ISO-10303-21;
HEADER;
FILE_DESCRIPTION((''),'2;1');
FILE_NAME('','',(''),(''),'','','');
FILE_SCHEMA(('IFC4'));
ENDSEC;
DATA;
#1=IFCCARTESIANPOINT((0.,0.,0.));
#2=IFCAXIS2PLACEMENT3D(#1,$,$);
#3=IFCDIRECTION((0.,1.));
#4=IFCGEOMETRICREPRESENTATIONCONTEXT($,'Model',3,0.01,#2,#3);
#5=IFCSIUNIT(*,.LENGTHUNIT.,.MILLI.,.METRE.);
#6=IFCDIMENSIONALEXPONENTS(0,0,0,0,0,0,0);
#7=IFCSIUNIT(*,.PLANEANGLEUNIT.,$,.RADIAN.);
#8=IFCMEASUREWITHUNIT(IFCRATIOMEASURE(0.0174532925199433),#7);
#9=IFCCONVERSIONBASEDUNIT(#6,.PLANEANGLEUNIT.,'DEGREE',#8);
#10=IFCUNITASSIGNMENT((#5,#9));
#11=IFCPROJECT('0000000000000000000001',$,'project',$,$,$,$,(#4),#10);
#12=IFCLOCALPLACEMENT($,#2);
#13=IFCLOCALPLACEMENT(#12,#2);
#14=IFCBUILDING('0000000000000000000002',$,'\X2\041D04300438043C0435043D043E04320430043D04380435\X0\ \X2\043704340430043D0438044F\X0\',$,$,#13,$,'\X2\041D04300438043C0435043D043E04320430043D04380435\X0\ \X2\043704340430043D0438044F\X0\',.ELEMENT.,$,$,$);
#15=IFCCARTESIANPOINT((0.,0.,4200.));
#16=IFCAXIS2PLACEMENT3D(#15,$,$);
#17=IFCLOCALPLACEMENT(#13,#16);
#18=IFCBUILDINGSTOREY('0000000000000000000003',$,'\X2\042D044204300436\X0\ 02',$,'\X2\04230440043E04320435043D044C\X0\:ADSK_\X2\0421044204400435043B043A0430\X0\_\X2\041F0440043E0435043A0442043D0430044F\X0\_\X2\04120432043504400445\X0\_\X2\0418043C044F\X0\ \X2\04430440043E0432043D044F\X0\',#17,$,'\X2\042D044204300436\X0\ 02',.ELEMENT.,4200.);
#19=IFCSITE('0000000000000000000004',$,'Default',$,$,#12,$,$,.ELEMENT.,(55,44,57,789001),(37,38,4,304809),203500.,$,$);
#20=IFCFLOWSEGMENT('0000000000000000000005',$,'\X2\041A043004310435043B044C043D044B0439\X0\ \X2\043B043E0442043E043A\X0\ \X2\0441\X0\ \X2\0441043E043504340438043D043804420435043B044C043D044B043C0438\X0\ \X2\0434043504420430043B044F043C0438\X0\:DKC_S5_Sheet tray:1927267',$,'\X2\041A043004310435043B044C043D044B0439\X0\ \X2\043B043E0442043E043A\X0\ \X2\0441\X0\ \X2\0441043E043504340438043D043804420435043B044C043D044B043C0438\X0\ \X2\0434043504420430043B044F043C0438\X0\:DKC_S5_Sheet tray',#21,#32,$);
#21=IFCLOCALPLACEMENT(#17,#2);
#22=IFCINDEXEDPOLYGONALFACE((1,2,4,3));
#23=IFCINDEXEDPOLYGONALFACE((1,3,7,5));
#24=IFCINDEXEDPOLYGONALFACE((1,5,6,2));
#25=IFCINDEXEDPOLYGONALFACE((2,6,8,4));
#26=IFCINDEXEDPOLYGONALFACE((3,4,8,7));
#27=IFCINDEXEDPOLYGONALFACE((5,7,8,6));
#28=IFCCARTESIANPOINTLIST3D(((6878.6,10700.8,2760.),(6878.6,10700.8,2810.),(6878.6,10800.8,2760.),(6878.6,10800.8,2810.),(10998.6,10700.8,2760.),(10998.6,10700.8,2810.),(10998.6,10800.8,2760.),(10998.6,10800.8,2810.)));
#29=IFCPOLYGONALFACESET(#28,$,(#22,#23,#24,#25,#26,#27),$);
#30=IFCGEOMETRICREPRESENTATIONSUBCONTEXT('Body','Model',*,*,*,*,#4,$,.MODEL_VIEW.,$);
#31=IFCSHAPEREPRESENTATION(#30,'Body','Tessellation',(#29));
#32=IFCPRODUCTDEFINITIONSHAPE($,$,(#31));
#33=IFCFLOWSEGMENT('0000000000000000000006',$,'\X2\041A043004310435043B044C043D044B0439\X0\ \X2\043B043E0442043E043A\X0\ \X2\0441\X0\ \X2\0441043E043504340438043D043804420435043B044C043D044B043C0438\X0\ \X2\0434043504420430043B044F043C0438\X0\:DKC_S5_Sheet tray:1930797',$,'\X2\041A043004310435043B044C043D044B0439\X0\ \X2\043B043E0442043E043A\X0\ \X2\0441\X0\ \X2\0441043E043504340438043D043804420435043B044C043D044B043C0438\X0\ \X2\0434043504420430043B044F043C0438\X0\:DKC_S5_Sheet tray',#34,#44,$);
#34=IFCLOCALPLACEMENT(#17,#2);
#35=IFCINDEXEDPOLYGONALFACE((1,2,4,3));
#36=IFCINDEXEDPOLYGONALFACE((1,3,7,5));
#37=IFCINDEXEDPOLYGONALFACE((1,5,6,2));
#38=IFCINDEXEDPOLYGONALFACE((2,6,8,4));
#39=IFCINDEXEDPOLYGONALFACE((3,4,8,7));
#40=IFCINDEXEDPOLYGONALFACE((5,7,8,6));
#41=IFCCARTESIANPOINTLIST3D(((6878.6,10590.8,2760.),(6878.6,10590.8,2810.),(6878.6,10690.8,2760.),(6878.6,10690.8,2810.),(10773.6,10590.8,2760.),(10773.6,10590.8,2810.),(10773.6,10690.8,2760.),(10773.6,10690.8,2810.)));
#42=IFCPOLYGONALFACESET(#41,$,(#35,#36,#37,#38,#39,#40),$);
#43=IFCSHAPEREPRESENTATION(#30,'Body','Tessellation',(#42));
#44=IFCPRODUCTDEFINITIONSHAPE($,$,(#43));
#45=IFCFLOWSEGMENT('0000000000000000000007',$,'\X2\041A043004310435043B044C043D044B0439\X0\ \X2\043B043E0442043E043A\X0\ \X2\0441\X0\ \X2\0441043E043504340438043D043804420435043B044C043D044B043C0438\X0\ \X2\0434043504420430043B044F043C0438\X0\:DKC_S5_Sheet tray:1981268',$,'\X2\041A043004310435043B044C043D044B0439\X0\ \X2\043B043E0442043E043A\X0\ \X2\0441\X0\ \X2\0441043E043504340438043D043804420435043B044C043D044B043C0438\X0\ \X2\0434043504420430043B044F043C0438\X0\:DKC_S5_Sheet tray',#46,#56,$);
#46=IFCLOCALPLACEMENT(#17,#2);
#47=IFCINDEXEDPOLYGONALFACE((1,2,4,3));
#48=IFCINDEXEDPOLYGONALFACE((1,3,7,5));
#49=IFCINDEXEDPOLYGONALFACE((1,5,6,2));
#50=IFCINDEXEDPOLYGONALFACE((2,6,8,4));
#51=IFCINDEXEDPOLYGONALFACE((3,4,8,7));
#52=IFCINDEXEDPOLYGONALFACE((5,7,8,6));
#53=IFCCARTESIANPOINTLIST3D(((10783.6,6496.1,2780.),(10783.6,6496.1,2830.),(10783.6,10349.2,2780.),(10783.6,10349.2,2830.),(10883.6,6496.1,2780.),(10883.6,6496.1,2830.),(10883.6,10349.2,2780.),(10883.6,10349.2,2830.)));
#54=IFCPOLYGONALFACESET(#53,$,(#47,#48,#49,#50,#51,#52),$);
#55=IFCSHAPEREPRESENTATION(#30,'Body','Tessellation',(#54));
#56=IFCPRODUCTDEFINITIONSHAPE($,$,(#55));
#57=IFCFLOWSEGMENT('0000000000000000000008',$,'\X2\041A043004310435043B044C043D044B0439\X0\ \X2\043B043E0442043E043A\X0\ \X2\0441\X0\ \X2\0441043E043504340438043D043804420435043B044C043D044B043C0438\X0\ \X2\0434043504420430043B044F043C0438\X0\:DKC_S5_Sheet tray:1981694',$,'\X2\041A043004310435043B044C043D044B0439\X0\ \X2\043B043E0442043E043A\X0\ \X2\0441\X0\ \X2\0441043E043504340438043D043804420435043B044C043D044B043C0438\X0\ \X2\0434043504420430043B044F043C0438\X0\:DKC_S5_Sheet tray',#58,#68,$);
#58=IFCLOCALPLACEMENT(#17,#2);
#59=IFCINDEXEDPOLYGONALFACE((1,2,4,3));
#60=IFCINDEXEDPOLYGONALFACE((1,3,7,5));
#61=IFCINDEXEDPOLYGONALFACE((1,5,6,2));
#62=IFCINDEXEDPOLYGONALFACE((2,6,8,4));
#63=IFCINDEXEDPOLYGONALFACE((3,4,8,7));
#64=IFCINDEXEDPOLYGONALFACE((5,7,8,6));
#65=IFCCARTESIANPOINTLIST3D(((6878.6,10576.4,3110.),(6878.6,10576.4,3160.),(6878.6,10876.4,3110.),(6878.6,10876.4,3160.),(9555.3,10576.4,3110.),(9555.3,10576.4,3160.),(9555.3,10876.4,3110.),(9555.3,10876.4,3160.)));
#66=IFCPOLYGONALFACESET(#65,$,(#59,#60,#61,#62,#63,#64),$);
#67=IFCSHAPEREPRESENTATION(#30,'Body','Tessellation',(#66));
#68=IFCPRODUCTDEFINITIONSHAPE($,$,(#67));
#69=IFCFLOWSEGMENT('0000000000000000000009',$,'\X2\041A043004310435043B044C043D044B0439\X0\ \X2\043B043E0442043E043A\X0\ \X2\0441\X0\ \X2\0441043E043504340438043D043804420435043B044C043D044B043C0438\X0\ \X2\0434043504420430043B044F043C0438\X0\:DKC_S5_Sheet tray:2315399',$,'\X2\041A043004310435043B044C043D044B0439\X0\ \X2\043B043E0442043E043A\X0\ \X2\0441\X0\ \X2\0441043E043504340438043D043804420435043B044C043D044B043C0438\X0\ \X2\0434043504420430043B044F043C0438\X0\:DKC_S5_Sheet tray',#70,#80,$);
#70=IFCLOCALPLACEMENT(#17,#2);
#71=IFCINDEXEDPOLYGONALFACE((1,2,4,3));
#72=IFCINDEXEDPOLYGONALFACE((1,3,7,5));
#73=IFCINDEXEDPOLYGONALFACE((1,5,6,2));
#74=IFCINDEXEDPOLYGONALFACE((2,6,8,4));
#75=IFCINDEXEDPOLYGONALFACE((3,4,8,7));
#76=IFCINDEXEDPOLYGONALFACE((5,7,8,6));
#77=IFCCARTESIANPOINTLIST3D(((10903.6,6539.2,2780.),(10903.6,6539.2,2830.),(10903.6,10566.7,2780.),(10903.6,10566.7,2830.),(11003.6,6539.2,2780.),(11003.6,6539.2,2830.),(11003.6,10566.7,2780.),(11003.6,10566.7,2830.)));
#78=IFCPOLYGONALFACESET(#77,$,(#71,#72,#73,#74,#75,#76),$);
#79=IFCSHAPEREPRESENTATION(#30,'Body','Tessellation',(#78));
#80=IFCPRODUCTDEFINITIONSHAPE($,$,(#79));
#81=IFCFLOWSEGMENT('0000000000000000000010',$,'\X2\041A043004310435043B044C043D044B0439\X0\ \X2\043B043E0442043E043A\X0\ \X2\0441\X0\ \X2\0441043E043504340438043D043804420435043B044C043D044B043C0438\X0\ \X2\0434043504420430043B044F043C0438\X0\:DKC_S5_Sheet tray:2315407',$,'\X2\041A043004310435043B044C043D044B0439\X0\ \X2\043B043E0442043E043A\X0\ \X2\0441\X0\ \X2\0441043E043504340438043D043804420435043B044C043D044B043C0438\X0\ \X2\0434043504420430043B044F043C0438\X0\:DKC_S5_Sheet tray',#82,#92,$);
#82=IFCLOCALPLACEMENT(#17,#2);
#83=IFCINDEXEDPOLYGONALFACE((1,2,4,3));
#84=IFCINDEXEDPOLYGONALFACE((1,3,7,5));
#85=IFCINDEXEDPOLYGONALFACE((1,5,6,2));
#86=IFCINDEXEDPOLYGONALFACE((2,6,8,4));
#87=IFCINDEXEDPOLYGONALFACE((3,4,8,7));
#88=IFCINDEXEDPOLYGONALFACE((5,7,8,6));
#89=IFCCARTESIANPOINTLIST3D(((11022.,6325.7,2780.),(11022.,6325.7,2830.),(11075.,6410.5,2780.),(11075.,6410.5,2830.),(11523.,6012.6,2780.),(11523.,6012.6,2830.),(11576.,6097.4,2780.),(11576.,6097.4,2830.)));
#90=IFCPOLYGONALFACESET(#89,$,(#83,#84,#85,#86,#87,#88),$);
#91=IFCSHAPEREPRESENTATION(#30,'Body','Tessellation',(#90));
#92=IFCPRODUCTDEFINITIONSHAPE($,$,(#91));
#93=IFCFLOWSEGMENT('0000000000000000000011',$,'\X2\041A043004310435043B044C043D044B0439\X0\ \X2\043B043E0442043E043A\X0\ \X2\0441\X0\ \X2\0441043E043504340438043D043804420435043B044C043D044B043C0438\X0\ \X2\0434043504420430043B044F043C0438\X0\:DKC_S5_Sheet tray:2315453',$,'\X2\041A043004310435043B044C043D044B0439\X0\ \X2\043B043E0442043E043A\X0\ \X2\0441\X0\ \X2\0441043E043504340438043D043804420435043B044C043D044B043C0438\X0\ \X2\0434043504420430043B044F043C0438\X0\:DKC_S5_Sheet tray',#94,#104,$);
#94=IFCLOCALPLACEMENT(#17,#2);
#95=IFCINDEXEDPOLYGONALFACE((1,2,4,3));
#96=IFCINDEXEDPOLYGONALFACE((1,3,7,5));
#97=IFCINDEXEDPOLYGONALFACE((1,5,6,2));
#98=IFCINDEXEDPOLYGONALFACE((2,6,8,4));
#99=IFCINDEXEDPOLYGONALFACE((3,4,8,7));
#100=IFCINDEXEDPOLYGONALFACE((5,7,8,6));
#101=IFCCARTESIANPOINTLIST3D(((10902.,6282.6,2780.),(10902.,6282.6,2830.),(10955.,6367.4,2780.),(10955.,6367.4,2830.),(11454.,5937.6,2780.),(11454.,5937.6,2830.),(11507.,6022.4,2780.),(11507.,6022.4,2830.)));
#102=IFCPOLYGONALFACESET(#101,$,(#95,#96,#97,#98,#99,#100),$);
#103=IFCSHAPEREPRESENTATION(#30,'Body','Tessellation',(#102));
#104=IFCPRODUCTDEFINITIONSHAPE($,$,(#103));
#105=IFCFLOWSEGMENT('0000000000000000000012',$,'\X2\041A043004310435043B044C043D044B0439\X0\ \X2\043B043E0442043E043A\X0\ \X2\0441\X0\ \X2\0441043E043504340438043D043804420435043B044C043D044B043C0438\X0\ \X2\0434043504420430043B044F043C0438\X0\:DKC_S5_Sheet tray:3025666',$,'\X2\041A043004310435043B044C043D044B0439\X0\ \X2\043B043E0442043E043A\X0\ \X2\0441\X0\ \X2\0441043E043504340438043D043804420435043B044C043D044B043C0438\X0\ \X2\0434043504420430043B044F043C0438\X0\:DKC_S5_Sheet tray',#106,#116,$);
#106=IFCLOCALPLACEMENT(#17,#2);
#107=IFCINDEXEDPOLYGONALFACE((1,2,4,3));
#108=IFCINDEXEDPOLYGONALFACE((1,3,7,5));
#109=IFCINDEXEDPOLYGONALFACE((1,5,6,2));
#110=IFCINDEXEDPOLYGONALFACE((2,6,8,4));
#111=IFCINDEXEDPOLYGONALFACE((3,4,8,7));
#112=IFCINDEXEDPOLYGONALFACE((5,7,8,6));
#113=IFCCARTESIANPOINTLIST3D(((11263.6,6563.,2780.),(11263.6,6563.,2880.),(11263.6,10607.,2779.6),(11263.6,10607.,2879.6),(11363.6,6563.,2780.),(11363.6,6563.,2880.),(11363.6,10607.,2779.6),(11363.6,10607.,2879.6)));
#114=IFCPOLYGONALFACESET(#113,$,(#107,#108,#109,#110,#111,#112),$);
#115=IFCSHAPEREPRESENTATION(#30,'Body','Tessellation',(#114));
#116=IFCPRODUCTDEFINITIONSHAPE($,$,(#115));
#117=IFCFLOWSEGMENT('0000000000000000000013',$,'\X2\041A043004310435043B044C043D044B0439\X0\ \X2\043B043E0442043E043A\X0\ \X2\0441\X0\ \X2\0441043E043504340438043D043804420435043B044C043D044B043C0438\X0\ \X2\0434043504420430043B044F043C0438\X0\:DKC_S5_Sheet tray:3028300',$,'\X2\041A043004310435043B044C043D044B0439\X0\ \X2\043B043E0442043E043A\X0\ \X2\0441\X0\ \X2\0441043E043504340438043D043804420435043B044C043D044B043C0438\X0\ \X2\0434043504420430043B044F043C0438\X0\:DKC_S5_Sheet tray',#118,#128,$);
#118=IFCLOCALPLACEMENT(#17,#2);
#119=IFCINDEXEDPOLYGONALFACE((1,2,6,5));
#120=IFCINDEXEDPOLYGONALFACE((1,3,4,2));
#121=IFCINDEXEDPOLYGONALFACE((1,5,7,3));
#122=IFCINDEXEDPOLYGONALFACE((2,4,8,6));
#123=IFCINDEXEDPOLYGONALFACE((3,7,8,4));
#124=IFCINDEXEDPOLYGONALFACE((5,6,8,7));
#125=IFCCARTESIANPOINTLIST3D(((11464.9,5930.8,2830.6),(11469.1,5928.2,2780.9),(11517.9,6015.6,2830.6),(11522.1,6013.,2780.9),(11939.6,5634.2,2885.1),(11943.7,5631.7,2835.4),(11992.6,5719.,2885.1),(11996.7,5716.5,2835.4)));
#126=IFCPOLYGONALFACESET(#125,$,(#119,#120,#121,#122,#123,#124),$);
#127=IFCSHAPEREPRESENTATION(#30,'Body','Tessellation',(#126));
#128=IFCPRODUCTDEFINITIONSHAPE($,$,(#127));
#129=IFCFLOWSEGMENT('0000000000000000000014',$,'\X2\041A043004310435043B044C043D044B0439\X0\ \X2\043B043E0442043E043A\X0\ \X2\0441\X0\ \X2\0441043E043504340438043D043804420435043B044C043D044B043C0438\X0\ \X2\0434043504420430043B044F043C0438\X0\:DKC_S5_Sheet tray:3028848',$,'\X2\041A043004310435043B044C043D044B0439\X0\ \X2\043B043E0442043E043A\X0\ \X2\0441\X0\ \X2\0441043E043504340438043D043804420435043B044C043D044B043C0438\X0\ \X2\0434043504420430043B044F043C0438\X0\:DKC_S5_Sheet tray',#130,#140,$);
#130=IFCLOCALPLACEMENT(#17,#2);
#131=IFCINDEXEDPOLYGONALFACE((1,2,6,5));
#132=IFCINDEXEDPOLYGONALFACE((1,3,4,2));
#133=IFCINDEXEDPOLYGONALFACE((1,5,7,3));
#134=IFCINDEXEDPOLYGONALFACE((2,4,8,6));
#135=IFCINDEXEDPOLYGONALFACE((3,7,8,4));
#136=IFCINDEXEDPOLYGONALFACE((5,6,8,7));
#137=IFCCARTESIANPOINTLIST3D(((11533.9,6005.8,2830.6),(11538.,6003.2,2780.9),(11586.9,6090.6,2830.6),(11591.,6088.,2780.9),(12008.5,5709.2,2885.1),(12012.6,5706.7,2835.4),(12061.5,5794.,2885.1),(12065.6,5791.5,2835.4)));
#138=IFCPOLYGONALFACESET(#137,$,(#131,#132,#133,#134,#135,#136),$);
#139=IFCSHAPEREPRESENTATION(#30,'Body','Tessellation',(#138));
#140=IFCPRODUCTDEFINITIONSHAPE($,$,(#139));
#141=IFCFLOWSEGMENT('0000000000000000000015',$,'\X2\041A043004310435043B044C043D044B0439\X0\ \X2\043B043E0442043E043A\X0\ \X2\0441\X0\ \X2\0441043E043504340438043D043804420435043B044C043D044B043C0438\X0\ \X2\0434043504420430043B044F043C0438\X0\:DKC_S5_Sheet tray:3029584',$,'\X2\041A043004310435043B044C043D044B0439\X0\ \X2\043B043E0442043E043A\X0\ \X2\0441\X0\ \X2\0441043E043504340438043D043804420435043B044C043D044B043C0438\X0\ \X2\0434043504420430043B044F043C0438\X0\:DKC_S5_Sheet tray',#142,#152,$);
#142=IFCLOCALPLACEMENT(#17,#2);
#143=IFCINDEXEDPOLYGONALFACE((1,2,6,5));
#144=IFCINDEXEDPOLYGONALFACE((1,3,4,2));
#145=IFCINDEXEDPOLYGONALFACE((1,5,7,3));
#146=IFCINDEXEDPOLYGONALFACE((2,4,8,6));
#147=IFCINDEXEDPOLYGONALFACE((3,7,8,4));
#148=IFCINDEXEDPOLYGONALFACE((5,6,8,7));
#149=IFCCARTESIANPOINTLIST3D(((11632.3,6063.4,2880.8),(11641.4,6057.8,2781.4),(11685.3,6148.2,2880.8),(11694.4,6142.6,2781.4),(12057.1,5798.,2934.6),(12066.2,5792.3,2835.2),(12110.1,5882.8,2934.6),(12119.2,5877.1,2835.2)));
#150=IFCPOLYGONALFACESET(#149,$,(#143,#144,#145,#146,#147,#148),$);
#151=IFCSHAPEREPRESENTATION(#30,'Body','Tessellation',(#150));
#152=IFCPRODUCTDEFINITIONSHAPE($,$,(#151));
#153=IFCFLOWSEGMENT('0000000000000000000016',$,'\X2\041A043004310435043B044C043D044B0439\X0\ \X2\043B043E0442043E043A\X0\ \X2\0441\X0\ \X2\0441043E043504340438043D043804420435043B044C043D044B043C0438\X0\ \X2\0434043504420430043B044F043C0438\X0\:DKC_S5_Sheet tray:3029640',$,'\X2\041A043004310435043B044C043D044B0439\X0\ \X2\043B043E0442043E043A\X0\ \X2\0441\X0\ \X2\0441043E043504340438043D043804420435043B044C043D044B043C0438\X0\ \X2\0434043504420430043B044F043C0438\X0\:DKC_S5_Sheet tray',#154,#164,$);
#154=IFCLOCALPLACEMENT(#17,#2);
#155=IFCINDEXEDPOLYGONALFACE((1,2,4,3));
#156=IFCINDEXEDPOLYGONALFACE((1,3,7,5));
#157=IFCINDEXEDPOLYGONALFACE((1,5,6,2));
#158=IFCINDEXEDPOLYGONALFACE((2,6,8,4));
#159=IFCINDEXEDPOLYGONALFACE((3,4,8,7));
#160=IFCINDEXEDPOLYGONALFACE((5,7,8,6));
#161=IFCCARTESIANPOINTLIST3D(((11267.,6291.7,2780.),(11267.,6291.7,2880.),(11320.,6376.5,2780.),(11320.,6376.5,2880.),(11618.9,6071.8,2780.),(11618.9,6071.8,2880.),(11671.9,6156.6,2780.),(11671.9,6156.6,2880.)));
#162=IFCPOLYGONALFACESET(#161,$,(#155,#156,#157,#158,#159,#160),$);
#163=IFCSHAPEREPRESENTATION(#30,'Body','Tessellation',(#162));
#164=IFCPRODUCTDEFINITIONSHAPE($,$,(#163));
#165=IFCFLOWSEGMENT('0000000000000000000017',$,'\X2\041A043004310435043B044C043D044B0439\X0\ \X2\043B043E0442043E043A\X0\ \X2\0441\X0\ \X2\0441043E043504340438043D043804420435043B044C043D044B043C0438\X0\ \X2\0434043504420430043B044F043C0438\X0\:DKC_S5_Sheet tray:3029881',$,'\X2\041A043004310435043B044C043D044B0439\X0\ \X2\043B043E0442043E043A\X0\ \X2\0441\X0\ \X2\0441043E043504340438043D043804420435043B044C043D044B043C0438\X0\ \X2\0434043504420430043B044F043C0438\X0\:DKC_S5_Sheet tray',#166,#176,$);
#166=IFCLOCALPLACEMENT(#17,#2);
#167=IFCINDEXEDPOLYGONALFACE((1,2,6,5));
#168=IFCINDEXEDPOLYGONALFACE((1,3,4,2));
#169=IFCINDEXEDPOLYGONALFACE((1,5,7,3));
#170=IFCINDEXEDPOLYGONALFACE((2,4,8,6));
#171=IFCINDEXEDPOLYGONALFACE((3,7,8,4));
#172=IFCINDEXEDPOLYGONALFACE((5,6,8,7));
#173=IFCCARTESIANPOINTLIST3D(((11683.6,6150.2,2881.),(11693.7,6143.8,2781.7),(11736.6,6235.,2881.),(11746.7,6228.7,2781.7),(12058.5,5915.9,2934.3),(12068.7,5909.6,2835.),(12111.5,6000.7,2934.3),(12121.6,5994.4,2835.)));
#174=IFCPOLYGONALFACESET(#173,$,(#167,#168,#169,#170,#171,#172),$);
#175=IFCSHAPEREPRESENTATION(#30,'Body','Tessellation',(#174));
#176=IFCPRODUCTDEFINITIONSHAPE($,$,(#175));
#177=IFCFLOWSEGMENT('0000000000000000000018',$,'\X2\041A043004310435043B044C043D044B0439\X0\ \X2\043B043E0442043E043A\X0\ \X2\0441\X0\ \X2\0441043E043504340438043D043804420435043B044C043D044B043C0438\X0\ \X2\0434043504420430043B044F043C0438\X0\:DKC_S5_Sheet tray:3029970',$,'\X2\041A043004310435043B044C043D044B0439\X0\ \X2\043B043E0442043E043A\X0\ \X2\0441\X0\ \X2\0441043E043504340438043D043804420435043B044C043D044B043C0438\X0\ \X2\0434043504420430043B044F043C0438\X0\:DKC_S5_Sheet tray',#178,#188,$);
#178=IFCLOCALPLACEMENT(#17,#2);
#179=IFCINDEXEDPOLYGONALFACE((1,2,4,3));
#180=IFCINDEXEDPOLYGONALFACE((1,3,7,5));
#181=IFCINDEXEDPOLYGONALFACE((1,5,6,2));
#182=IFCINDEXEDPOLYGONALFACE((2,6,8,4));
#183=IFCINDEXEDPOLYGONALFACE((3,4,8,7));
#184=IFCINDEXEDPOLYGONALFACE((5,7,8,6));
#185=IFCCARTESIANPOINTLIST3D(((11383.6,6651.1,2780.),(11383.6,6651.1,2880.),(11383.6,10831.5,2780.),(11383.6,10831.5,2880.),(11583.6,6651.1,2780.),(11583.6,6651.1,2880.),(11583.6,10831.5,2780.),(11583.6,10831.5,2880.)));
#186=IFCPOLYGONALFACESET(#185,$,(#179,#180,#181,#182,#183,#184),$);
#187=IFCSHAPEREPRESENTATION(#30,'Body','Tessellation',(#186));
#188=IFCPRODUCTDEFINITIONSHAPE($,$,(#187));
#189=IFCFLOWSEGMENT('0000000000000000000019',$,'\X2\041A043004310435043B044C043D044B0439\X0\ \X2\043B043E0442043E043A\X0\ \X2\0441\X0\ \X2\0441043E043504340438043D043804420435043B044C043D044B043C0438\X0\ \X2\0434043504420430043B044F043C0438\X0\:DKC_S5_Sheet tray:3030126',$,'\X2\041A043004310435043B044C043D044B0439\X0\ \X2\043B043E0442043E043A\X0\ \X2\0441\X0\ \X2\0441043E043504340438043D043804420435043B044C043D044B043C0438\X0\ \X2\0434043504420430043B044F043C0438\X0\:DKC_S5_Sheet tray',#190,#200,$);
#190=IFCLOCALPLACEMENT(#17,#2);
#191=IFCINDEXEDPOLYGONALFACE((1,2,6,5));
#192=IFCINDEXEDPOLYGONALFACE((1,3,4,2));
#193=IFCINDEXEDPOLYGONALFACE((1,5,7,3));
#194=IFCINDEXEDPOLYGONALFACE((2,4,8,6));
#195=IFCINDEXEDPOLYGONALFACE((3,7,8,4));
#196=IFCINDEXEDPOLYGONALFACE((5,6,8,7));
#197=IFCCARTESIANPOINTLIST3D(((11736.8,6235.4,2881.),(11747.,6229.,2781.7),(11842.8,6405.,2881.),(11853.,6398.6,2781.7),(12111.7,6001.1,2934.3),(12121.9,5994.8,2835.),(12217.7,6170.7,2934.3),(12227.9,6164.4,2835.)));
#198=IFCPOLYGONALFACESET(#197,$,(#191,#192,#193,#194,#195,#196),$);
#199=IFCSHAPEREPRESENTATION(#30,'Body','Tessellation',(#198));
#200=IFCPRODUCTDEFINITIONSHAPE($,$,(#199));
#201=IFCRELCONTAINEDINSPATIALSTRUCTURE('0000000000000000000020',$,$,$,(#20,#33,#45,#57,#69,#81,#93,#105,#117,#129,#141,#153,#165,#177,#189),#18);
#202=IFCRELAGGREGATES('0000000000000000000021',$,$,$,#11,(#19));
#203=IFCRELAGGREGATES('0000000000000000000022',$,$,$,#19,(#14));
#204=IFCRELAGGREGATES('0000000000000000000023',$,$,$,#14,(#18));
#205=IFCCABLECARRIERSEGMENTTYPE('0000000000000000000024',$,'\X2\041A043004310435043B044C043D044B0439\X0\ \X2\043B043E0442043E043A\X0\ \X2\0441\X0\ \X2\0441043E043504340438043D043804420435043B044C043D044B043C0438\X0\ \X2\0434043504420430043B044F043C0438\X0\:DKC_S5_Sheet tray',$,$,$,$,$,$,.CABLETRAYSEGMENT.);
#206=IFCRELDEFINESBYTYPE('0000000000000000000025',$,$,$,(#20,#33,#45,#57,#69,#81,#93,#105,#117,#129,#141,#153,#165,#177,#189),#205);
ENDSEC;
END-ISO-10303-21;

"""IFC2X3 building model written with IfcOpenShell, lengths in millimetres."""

from ifc_helpers import new_model, entity, si_unit, converted_unit, direction, frame, frame_2d, origin, origin_2d_with_axis, place, context, subcontext, project, spatial, rectangle, extrude, type_object, element, save


model = new_model("IFC2X3")

# Units and contexts
model_context = context("Model", 3, precision=0.01, world=origin(), true_north=direction((0.0, 1.0)))
body_context = subcontext(model_context, "Body", "Model", "MODEL_VIEW")
ifc_project = project(units=[si_unit("LENGTHUNIT", "METRE", prefix="MILLI"), converted_unit("PLANEANGLEUNIT", "DEGREE", entity("IfcRatioMeasure", 0.0174532925199433), si_unit("PLANEANGLEUNIT", "RADIAN"), dimensions=[0, 0, 0, 0, 0, 0, 0])], contexts=[model_context])

# Site, building, storey
site_placement = place(None, origin())
site = spatial("IfcSite", under=ifc_project, at=site_placement, Name="Default", CompositionType="ELEMENT", RefLatitude=(55, 44, 57, 789001), RefLongitude=(37, 38, 4, 304809), RefElevation=203500.0)
building_placement = place(site_placement, origin())
building = spatial("IfcBuilding", under=site, at=building_placement, Name="Наименование здания", LongName="Наименование здания", CompositionType="ELEMENT")
storey_placement = place(building_placement, frame((0.0, 0.0, 4200.0)))
storey = spatial("IfcBuildingStorey", under=building, at=storey_placement, Name="Этаж 02", ObjectType="Уровень:ADSK_Стрелка_Проектная_Вверх_Имя уровня", LongName="Этаж 02", CompositionType="ELEMENT", Elevation=4200.0)

# Flow segments
cable_carrier_segment_type = type_object("IfcCableCarrierSegmentType", Name="Кабельный лоток с соединительными деталями:DKC_S5_Sheet tray", PredefinedType="CABLETRAYSEGMENT")
flow_segment_1_placement = place(storey_placement, frame((6878.6, 10700.8, 2760.0)))
element("IfcFlowSegment", 1, at=flow_segment_1_placement, inside=storey, type_object=cable_carrier_segment_type, Name="Кабельный лоток с соединительными деталями:DKC_S5_Sheet tray:1927267", ObjectType="Кабельный лоток с соединительными деталями:DKC_S5_Sheet tray", context=body_context, shape_type="SweptSolid", body=[
    extrude(rectangle(XDim=4120.0, YDim=100.0, at=origin_2d_with_axis()), frame((2060.0, 50.0, 0.0), z_axis=(0.0, 0.0, 1.0), x_axis=(-1.0, 0.0, 0.0)), (0.0, 0.0, 1.0), 50.0),
])
flow_segment_2_placement = place(storey_placement, frame((6878.6, 10590.8, 2760.0)))
element("IfcFlowSegment", 2, at=flow_segment_2_placement, inside=storey, type_object=cable_carrier_segment_type, Name="Кабельный лоток с соединительными деталями:DKC_S5_Sheet tray:1930797", ObjectType="Кабельный лоток с соединительными деталями:DKC_S5_Sheet tray", context=body_context, shape_type="SweptSolid", body=[
    extrude(rectangle(XDim=3895.0, YDim=100.0, at=origin_2d_with_axis()), frame((1947.5, 50.0, 0.0), z_axis=(0.0, 0.0, 1.0), x_axis=(-1.0, 0.0, 0.0)), (0.0, 0.0, 1.0), 50.0),
])
flow_segment_3_placement = place(storey_placement, frame((10783.6, 6496.1, 2780.0)))
element("IfcFlowSegment", 3, at=flow_segment_3_placement, inside=storey, type_object=cable_carrier_segment_type, Name="Кабельный лоток с соединительными деталями:DKC_S5_Sheet tray:1981268", ObjectType="Кабельный лоток с соединительными деталями:DKC_S5_Sheet tray", context=body_context, shape_type="SweptSolid", body=[
    extrude(rectangle(XDim=3853.0, YDim=100.0, at=origin_2d_with_axis()), frame((50.0, 1926.5, 0.0), z_axis=(0.0, 0.0, 1.0), x_axis=(0.0, -1.0, 0.0)), (0.0, 0.0, 1.0), 50.0),
])
flow_segment_4_placement = place(storey_placement, frame((6878.6, 10576.4, 3110.0)))
element("IfcFlowSegment", 4, at=flow_segment_4_placement, inside=storey, type_object=cable_carrier_segment_type, Name="Кабельный лоток с соединительными деталями:DKC_S5_Sheet tray:1981694", ObjectType="Кабельный лоток с соединительными деталями:DKC_S5_Sheet tray", context=body_context, shape_type="SweptSolid", body=[
    extrude(rectangle(XDim=2676.7, YDim=300.0, at=origin_2d_with_axis()), frame((1338.3, 150.0, 0.0), z_axis=(0.0, 0.0, 1.0), x_axis=(-1.0, 0.0, 0.0)), (0.0, 0.0, 1.0), 50.0),
])
flow_segment_5_placement = place(storey_placement, frame((10903.6, 6539.2, 2780.0)))
element("IfcFlowSegment", 5, at=flow_segment_5_placement, inside=storey, type_object=cable_carrier_segment_type, Name="Кабельный лоток с соединительными деталями:DKC_S5_Sheet tray:2315399", ObjectType="Кабельный лоток с соединительными деталями:DKC_S5_Sheet tray", context=body_context, shape_type="SweptSolid", body=[
    extrude(rectangle(XDim=4027.5, YDim=100.0, at=origin_2d_with_axis()), frame((50.0, 2013.7, 0.0), z_axis=(0.0, 0.0, 1.0), x_axis=(0.0, -1.0, 0.0)), (0.0, 0.0, 1.0), 50.0),
])
flow_segment_6_placement = place(storey_placement, frame((11022.0, 6012.6, 2780.0)))
element("IfcFlowSegment", 6, at=flow_segment_6_placement, inside=storey, type_object=cable_carrier_segment_type, Name="Кабельный лоток с соединительными деталями:DKC_S5_Sheet tray:2315407", ObjectType="Кабельный лоток с соединительными деталями:DKC_S5_Sheet tray", context=body_context, shape_type="SweptSolid", body=[
    extrude(rectangle(XDim=590.8, YDim=100.0, at=origin_2d_with_axis()), frame((277.0, 198.9, 0.0), z_axis=(0.0, 0.0, 1.0), x_axis=(-0.848048, 0.529919, 0.0)), (0.0, 0.0, 1.0), 50.0),
])
flow_segment_7_placement = place(storey_placement, frame((10902.0, 5937.6, 2780.0)))
element("IfcFlowSegment", 7, at=flow_segment_7_placement, inside=storey, type_object=cable_carrier_segment_type, Name="Кабельный лоток с соединительными деталями:DKC_S5_Sheet tray:2315453", ObjectType="Кабельный лоток с соединительными деталями:DKC_S5_Sheet tray", context=body_context, shape_type="SweptSolid", body=[
    extrude(rectangle(XDim=651.0, YDim=100.0, at=origin_2d_with_axis()), frame((302.5, 214.9, 0.0), z_axis=(0.0, 0.0, 1.0), x_axis=(-0.848048, 0.529919, 0.0)), (0.0, 0.0, 1.0), 50.0),
])
flow_segment_8_placement = place(storey_placement, frame((11263.6, 6563.0, 2779.6)))
element("IfcFlowSegment", 8, at=flow_segment_8_placement, inside=storey, type_object=cable_carrier_segment_type, Name="Кабельный лоток с соединительными деталями:DKC_S5_Sheet tray:3025666", ObjectType="Кабельный лоток с соединительными деталями:DKC_S5_Sheet tray", context=body_context, shape_type="SweptSolid", body=[
    extrude(rectangle(XDim=4044.1, YDim=100.0, at=origin_2d_with_axis()), frame((50.0, 2022.0, 0.2), z_axis=(0.0, 0.000098, 1.0), x_axis=(0.0, -1.0, 0.000098)), (0.0, 0.0, 1.0), 100.0),
])
flow_segment_9_placement = place(storey_placement, frame((11465.0, 5631.7, 2780.9)))
element("IfcFlowSegment", 9, at=flow_segment_9_placement, inside=storey, type_object=cable_carrier_segment_type, Name="Кабельный лоток с соединительными деталями:DKC_S5_Sheet tray:3028300", ObjectType="Кабельный лоток с соединительными деталями:DKC_S5_Sheet tray", context=body_context, shape_type="SweptSolid", body=[
    extrude(rectangle(XDim=50.0, YDim=100.0, at=frame_2d((0.0, 0.0), x_axis=(0.0, 1.0))), frame((28.6, 340.3, 24.9), z_axis=(0.844054, -0.527423, 0.096942), x_axis=(0.529919, 0.848048, 0.0)), (0.0, 0.0, 1.0), 562.3),
])
flow_segment_10_placement = place(storey_placement, frame((11533.9, 5706.6, 2780.9)))
element("IfcFlowSegment", 10, at=flow_segment_10_placement, inside=storey, type_object=cable_carrier_segment_type, Name="Кабельный лоток с соединительными деталями:DKC_S5_Sheet tray:3028848", ObjectType="Кабельный лоток с соединительными деталями:DKC_S5_Sheet tray", context=body_context, shape_type="SweptSolid", body=[
    extrude(rectangle(XDim=50.0, YDim=100.0, at=origin_2d_with_axis()), frame((28.6, 340.3, 24.9), z_axis=(0.844054, -0.527423, 0.096942), x_axis=(-0.082211, 0.051371, 0.99529)), (0.0, 0.0, 1.0), 562.3),
])
flow_segment_11_placement = place(storey_placement, frame((11632.3, 5792.3, 2781.4)))
element("IfcFlowSegment", 11, at=flow_segment_11_placement, inside=storey, type_object=cable_carrier_segment_type, Name="Кабельный лоток с соединительными деталями:DKC_S5_Sheet tray:3029584", ObjectType="Кабельный лоток с соединительными деталями:DKC_S5_Sheet tray", context=body_context, shape_type="SweptSolid", body=[
    extrude(rectangle(XDim=100.0, YDim=100.0, at=origin_2d_with_axis()), frame((31.0, 310.7, 49.7), z_axis=(0.84321, -0.526896, 0.106663), x_axis=(-0.090456, 0.056523, 0.994295)), (0.0, 0.0, 1.0), 503.8),
])
flow_segment_12_placement = place(storey_placement, frame((11267.0, 6071.8, 2780.0)))
element("IfcFlowSegment", 12, at=flow_segment_12_placement, inside=storey, type_object=cable_carrier_segment_type, Name="Кабельный лоток с соединительными деталями:DKC_S5_Sheet tray:3029640", ObjectType="Кабельный лоток с соединительными деталями:DKC_S5_Sheet tray", context=body_context, shape_type="SweptSolid", body=[
    extrude(rectangle(XDim=415.0, YDim=100.0, at=origin_2d_with_axis()), frame((202.5, 152.4, 0.0), z_axis=(0.0, 0.0, 1.0), x_axis=(-0.848048, 0.529919, 0.0)), (0.0, 0.0, 1.0), 100.0),
])
flow_segment_13_placement = place(storey_placement, frame((11683.6, 5909.6, 2781.7)))
element("IfcFlowSegment", 13, at=flow_segment_13_placement, inside=storey, type_object=cable_carrier_segment_type, Name="Кабельный лоток с соединительными деталями:DKC_S5_Sheet tray:3029881", ObjectType="Кабельный лоток с соединительными деталями:DKC_S5_Sheet tray", context=body_context, shape_type="SweptSolid", body=[
    extrude(rectangle(XDim=100.0, YDim=100.0, at=frame_2d((0.0, 0.0), x_axis=(0.0, 1.0))), frame((31.6, 279.8, 49.6), z_axis=(0.841952, -0.52611, 0.119685), x_axis=(0.529919, 0.848048, 0.0)), (0.0, 0.0, 1.0), 445.3),
])
flow_segment_14_placement = place(storey_placement, frame((11383.6, 6651.1, 2780.0)))
element("IfcFlowSegment", 14, at=flow_segment_14_placement, inside=storey, type_object=cable_carrier_segment_type, Name="Кабельный лоток с соединительными деталями:DKC_S5_Sheet tray:3029970", ObjectType="Кабельный лоток с соединительными деталями:DKC_S5_Sheet tray", context=body_context, shape_type="SweptSolid", body=[
    extrude(rectangle(XDim=4180.4, YDim=200.0, at=origin_2d_with_axis()), frame((100.0, 2090.2, 0.0), z_axis=(0.0, 0.0, 1.0), x_axis=(0.0, 1.0, 0.0)), (0.0, 0.0, 1.0), 100.0),
])
flow_segment_15_placement = place(storey_placement, frame((11736.8, 5994.8, 2781.7)))
element("IfcFlowSegment", 15, at=flow_segment_15_placement, inside=storey, type_object=cable_carrier_segment_type, Name="Кабельный лоток с соединительными деталями:DKC_S5_Sheet tray:3030126", ObjectType="Кабельный лоток с соединительными деталями:DKC_S5_Sheet tray", context=body_context, shape_type="SweptSolid", body=[
    extrude(rectangle(XDim=100.0, YDim=200.0, at=frame_2d((0.0, 0.0), x_axis=(0.0, 1.0))), frame((58.1, 322.2, 49.6), z_axis=(0.841952, -0.52611, 0.119685), x_axis=(0.529919, 0.848048, 0.0)), (0.0, 0.0, 1.0), 445.3),
])

save(model, "model.ifc")
